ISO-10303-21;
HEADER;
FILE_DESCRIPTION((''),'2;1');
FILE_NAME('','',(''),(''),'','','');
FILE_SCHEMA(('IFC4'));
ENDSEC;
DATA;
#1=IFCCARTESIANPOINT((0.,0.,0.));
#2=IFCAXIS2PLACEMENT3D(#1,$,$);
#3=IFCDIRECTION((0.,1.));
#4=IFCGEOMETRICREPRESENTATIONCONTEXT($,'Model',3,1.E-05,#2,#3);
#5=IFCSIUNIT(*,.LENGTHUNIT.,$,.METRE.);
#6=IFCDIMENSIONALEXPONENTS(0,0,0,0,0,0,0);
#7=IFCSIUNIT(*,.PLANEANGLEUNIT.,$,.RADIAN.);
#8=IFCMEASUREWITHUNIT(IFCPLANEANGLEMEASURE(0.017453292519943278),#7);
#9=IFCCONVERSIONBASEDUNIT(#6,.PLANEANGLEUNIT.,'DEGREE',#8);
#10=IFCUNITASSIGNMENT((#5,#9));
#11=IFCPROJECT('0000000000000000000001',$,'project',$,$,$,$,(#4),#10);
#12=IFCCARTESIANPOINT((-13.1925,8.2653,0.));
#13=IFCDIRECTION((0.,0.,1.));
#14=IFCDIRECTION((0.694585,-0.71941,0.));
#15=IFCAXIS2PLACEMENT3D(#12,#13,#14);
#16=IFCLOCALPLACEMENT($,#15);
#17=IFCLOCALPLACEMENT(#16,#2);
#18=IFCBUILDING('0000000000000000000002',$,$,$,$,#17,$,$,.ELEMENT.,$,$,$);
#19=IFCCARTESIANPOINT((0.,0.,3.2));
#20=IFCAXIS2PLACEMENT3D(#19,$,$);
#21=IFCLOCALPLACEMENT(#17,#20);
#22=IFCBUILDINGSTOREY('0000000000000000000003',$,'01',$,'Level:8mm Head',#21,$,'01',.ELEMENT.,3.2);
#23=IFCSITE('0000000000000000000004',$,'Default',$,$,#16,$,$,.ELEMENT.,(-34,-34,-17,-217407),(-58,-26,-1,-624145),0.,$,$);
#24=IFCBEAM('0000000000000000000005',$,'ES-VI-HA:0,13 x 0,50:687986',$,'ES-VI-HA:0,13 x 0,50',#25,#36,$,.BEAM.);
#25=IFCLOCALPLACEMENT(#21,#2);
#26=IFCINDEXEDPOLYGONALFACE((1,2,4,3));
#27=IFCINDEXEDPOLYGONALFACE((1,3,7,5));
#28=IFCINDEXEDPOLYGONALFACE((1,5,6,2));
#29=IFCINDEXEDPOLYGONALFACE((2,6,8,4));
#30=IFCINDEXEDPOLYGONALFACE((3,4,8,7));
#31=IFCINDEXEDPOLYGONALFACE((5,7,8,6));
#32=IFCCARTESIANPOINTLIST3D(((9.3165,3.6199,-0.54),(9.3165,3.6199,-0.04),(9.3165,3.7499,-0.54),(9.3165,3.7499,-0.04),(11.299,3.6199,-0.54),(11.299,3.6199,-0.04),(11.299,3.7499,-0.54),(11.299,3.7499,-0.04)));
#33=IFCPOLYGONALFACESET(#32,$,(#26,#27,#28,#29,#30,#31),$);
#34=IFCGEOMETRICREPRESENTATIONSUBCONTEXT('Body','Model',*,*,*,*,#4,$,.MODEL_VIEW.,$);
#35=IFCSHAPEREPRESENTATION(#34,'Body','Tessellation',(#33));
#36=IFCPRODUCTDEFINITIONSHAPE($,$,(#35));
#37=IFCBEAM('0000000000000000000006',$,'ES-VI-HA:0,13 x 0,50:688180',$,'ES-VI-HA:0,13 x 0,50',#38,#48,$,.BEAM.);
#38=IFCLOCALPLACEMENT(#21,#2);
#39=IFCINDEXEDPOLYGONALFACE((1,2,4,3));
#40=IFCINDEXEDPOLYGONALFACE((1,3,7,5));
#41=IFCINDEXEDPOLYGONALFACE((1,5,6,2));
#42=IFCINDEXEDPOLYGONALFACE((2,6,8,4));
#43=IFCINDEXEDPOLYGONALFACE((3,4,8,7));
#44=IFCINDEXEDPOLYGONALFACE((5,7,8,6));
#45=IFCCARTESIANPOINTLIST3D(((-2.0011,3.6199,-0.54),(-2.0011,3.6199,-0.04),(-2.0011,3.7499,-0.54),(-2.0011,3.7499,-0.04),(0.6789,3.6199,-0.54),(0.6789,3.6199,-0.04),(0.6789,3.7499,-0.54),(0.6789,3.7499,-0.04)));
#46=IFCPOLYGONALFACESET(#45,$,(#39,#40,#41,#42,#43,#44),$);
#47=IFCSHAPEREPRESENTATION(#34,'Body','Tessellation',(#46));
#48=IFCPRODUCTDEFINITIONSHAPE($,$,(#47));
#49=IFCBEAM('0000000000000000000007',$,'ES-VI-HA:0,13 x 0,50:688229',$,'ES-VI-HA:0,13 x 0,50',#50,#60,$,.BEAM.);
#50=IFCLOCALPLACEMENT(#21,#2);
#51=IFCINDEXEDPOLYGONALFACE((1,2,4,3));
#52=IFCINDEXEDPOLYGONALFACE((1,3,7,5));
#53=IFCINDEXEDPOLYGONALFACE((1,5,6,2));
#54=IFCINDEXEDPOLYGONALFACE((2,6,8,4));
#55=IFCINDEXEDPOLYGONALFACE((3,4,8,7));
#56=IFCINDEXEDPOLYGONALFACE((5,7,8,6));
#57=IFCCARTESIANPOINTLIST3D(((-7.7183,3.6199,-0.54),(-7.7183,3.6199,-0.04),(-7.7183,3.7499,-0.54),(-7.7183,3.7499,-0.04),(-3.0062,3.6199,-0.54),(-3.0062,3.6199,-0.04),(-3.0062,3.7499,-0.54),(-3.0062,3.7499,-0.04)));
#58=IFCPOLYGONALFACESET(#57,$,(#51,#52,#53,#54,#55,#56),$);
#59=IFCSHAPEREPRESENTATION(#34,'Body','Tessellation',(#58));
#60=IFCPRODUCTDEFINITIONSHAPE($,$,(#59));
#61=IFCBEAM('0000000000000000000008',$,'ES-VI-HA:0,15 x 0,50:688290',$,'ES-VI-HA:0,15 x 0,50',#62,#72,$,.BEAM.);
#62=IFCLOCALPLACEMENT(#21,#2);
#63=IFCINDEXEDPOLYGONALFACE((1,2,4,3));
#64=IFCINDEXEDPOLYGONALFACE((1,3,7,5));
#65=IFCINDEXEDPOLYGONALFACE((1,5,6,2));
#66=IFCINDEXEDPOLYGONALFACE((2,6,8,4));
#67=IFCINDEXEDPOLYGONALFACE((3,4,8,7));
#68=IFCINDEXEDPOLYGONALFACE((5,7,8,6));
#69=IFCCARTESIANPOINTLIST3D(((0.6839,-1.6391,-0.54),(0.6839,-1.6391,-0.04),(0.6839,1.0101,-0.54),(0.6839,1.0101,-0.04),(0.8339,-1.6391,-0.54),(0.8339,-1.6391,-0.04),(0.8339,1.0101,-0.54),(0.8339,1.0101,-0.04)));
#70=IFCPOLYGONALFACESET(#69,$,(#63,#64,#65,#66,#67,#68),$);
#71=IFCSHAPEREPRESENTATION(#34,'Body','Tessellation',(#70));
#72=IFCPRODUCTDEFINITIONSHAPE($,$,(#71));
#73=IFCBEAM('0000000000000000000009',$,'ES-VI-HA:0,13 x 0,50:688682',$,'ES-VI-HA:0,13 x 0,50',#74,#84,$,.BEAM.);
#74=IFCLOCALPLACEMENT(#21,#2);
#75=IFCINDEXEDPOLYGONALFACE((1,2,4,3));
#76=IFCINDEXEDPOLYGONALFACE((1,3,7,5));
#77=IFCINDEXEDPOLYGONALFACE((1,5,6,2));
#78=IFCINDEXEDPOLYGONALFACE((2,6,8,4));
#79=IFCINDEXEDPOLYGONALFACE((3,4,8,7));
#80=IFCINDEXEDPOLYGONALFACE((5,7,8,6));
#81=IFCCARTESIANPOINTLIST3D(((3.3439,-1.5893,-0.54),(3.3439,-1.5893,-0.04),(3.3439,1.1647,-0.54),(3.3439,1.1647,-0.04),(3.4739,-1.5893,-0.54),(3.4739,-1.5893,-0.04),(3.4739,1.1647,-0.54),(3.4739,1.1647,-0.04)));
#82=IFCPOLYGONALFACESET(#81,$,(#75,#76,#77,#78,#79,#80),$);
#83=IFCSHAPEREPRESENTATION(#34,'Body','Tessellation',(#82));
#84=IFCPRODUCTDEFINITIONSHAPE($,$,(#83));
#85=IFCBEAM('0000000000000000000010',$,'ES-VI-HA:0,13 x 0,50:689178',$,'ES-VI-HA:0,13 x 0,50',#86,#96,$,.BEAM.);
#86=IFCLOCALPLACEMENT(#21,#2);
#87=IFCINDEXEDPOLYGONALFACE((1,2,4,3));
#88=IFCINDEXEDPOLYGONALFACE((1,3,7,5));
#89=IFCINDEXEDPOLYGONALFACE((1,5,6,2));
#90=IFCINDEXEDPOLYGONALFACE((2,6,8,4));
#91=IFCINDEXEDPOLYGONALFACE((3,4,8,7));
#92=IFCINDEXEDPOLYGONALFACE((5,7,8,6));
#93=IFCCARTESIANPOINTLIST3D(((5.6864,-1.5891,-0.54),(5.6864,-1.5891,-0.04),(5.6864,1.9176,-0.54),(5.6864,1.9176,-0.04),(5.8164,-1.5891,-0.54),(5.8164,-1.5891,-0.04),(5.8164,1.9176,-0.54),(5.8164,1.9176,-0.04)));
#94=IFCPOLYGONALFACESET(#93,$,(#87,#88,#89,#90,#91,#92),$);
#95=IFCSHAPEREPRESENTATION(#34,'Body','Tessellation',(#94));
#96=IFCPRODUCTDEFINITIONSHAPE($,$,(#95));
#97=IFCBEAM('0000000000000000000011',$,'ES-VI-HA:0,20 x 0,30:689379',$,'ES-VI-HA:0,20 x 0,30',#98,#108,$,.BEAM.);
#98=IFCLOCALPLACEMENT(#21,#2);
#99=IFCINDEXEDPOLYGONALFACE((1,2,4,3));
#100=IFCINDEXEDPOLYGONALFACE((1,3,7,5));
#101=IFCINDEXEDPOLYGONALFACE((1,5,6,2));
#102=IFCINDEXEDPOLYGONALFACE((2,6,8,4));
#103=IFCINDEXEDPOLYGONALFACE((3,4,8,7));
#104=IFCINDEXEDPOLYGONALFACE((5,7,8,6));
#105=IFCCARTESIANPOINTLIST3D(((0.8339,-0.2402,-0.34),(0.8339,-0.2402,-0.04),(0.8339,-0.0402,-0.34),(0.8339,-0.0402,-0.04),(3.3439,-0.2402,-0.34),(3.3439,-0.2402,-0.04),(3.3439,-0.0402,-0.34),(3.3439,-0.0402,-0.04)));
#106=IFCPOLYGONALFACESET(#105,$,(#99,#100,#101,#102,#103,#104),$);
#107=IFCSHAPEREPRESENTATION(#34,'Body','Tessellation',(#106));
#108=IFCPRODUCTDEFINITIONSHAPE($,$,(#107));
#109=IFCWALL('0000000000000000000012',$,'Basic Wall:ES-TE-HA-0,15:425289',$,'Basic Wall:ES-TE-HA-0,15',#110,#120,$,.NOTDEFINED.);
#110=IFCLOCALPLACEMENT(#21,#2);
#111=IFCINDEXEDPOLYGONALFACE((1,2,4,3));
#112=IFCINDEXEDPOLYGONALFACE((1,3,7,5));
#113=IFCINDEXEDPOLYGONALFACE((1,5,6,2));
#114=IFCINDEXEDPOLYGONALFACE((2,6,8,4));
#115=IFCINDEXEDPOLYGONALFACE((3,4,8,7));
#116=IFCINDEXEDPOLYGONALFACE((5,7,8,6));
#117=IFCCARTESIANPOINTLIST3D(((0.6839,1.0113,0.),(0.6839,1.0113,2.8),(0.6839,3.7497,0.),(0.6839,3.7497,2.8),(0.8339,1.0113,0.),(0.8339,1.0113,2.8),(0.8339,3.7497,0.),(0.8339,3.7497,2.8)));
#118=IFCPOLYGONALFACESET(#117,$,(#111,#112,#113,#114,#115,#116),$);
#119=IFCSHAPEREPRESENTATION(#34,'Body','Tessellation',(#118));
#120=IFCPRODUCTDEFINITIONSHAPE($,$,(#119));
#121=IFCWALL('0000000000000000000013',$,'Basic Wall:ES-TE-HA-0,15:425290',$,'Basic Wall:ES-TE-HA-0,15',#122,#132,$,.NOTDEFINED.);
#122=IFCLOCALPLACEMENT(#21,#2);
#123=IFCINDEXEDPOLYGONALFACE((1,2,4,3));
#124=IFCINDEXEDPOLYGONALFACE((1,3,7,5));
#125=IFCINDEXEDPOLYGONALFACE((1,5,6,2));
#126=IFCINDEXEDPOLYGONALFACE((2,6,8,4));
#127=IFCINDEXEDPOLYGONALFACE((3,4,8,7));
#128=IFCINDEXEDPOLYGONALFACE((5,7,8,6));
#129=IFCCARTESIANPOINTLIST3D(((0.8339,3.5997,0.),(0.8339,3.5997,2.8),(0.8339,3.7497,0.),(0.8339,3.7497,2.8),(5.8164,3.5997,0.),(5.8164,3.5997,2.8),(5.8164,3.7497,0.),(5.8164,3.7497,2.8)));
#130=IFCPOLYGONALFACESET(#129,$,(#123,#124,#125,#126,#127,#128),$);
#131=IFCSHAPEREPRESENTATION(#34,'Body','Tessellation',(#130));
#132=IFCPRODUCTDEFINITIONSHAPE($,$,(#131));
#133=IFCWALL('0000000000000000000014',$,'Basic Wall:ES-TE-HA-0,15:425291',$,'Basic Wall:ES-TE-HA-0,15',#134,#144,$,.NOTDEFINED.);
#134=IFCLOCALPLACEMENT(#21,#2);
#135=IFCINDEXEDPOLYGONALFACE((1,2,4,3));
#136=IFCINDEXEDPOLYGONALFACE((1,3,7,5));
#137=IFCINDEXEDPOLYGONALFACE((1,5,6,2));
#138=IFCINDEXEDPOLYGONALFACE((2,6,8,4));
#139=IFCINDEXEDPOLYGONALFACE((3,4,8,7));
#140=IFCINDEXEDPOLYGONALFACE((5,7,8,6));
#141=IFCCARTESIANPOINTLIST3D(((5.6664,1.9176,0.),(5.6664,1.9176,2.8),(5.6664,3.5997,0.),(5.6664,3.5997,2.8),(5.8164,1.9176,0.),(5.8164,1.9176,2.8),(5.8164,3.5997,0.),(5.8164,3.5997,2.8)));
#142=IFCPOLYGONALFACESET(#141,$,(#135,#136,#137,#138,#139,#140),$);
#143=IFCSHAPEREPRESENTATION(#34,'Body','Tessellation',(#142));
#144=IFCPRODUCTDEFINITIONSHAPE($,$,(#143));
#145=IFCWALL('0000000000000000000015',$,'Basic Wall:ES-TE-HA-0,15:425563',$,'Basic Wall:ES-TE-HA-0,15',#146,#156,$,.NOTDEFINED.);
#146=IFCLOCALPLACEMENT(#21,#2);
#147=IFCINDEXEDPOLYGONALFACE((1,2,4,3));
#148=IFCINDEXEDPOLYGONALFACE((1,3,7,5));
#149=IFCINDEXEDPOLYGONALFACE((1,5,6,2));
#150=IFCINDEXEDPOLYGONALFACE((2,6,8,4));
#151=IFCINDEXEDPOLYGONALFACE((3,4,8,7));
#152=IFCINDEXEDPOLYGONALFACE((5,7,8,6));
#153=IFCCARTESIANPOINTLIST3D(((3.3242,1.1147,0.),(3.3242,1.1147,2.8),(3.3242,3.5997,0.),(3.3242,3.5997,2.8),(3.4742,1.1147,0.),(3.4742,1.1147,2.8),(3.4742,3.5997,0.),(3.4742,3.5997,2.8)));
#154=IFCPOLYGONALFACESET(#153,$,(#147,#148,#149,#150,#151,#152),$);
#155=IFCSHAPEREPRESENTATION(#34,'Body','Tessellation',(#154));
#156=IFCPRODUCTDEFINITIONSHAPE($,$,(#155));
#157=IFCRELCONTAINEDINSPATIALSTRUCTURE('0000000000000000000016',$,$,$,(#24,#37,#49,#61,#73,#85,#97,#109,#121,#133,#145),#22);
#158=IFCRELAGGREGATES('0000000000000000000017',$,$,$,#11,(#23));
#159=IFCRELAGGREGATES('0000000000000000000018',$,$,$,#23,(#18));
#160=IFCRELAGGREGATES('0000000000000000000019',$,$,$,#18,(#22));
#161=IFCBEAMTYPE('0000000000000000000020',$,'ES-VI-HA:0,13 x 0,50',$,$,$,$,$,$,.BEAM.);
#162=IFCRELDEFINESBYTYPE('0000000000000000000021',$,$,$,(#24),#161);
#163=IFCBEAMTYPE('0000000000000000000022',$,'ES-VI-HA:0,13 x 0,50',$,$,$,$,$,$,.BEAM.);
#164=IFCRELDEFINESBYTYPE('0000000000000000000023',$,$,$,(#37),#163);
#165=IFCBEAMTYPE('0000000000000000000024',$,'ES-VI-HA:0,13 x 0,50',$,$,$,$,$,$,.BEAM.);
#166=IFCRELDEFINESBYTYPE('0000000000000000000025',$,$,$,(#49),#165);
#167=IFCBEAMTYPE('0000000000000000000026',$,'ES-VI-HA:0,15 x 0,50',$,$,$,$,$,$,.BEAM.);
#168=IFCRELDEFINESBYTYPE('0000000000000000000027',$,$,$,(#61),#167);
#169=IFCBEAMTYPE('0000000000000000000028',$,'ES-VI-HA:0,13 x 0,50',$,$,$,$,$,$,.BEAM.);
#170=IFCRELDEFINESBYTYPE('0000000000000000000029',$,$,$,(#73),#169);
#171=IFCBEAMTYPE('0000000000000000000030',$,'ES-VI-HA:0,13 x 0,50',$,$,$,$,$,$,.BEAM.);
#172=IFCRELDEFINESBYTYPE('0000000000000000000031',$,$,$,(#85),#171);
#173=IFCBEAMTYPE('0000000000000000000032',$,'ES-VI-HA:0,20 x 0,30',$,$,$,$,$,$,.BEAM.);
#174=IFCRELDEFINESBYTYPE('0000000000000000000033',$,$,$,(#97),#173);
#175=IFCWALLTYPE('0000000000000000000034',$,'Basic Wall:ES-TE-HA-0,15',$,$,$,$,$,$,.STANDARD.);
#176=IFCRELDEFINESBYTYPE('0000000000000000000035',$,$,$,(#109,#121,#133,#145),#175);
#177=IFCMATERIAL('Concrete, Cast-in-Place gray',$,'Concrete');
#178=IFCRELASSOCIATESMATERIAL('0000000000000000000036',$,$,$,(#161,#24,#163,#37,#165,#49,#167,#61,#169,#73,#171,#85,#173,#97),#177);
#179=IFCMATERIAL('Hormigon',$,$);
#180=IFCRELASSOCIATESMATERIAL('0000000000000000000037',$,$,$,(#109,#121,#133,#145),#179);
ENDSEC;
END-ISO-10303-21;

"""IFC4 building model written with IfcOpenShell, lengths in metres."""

from ifc_helpers import new_model, entity, si_unit, converted_unit, direction, frame, origin, place, context, subcontext, project, spatial, indexed_curve, outline, extrude, source, transform, mapped, material, type_object, type_shapes, element, save


model = new_model("IFC4")

# Units and contexts
model_context = context("Model", 3, precision=1e-05, world=origin(), true_north=direction((0.0, 1.0)))
body_context = subcontext(model_context, "Body", "Model", "MODEL_VIEW")
ifc_project = project(units=[si_unit("LENGTHUNIT", "METRE"), converted_unit("PLANEANGLEUNIT", "DEGREE", entity("IfcPlaneAngleMeasure", 0.017453292519943278), si_unit("PLANEANGLEUNIT", "RADIAN"), dimensions=[0, 0, 0, 0, 0, 0, 0])], contexts=[model_context])

# Site, building, storey
site_placement = place(None, frame((-13.1925, 8.2653, 0.0), z_axis=(0.0, 0.0, 1.0), x_axis=(0.694585, -0.71941, 0.0)))
site = spatial("IfcSite", under=ifc_project, at=site_placement, Name="Default", CompositionType="ELEMENT", RefLatitude=(-34, -34, -17, -217407), RefLongitude=(-58, -26, -1, -624145), RefElevation=0.0)
building_placement = place(site_placement, origin())
building = spatial("IfcBuilding", under=site, at=building_placement, CompositionType="ELEMENT")
storey_placement = place(building_placement, frame((0.0, 0.0, 3.2)))
storey = spatial("IfcBuildingStorey", under=building, at=storey_placement, Name="01", ObjectType="Level:8mm Head", LongName="01", CompositionType="ELEMENT", Elevation=3.2)

# Beams
ifc_material_1 = material(Name="Concrete, Cast-in-Place gray", Category="Concrete")
beam_type_1 = type_object("IfcBeamType", Name="ES-VI-HA:0,13 x 0,50", PredefinedType="BEAM", material=ifc_material_1)
shared_shape_1 = source(origin(), body_context, "Body", "SweptSolid", [
    extrude(outline(indexed_curve([(-0.25, -0.065), (0.25, -0.065), (0.25, 0.065), (-0.25, 0.065), (-0.25, -0.065)], self_intersect=False)), frame((9.3165, 3.6849, 2.91), z_axis=(1.0, 0.0, 0.0), x_axis=(0.0, 0.0, -1.0)), (0.0, 0.0, 1.0), 1.9825),
])
type_shapes(beam_type_1, [shared_shape_1])
beam_1_placement = place(storey_placement, frame((0.0, 0.0, -3.2)))
element("IfcBeam", 1, at=beam_1_placement, inside=storey, type_object=beam_type_1, material=ifc_material_1, Name="ES-VI-HA:0,13 x 0,50:687986", ObjectType="ES-VI-HA:0,13 x 0,50", PredefinedType="BEAM", context=body_context, shape_type="MappedRepresentation", body=[
    mapped(shared_shape_1, transform((0.0, 0.0, 0.0), scale=1.0)),
])
beam_type_2 = type_object("IfcBeamType", Name="ES-VI-HA:0,13 x 0,50", PredefinedType="BEAM", material=ifc_material_1)
shared_shape_2 = source(origin(), body_context, "Body", "SweptSolid", [
    extrude(outline(indexed_curve([(-0.25, -0.065), (0.25, -0.065), (0.25, 0.065), (-0.25, 0.065), (-0.25, -0.065)], self_intersect=False)), frame((-2.0011, 3.6849, 2.91), z_axis=(1.0, 0.0, 0.0), x_axis=(0.0, 0.0, -1.0)), (0.0, 0.0, 1.0), 2.68),
])
type_shapes(beam_type_2, [shared_shape_2])
beam_2_placement = place(storey_placement, frame((0.0, 0.0, -3.2)))
element("IfcBeam", 2, at=beam_2_placement, inside=storey, type_object=beam_type_2, material=ifc_material_1, Name="ES-VI-HA:0,13 x 0,50:688180", ObjectType="ES-VI-HA:0,13 x 0,50", PredefinedType="BEAM", context=body_context, shape_type="MappedRepresentation", body=[
    mapped(shared_shape_2, transform((0.0, 0.0, 0.0), scale=1.0)),
])
beam_type_3 = type_object("IfcBeamType", Name="ES-VI-HA:0,13 x 0,50", PredefinedType="BEAM", material=ifc_material_1)
shared_shape_3 = source(origin(), body_context, "Body", "SweptSolid", [
    extrude(outline(indexed_curve([(-0.25, -0.065), (0.25, -0.065), (0.25, 0.065), (-0.25, 0.065), (-0.25, -0.065)], self_intersect=False)), frame((-7.7183, 3.6849, 2.91), z_axis=(1.0, 0.0, 0.0), x_axis=(0.0, 0.0, -1.0)), (0.0, 0.0, 1.0), 4.712),
])
type_shapes(beam_type_3, [shared_shape_3])
beam_3_placement = place(storey_placement, frame((0.0, 0.0, -3.2)))
element("IfcBeam", 3, at=beam_3_placement, inside=storey, type_object=beam_type_3, material=ifc_material_1, Name="ES-VI-HA:0,13 x 0,50:688229", ObjectType="ES-VI-HA:0,13 x 0,50", PredefinedType="BEAM", context=body_context, shape_type="MappedRepresentation", body=[
    mapped(shared_shape_3, transform((0.0, 0.0, 0.0), scale=1.0)),
])
beam_type_4 = type_object("IfcBeamType", Name="ES-VI-HA:0,15 x 0,50", PredefinedType="BEAM", material=ifc_material_1)
shared_shape_4 = source(origin(), body_context, "Body", "SweptSolid", [
    extrude(outline(indexed_curve([(-0.075, -0.25), (0.075, -0.25), (0.075, 0.25), (-0.075, 0.25), (-0.075, -0.25)], self_intersect=False)), frame((0.7589, -1.6391, 2.91), z_axis=(0.0, 1.0, 0.0), x_axis=(-1.0, 0.0, 0.0)), (0.0, 0.0, 1.0), 2.6491),
])
type_shapes(beam_type_4, [shared_shape_4])
beam_4_placement = place(storey_placement, frame((0.0, 0.0, -3.2)))
element("IfcBeam", 4, at=beam_4_placement, inside=storey, type_object=beam_type_4, material=ifc_material_1, Name="ES-VI-HA:0,15 x 0,50:688290", ObjectType="ES-VI-HA:0,15 x 0,50", PredefinedType="BEAM", context=body_context, shape_type="MappedRepresentation", body=[
    mapped(shared_shape_4, transform((0.0, 0.0, 0.0), scale=1.0)),
])
beam_type_5 = type_object("IfcBeamType", Name="ES-VI-HA:0,13 x 0,50", PredefinedType="BEAM", material=ifc_material_1)
shared_shape_5 = source(origin(), body_context, "Body", "SweptSolid", [
    extrude(outline(indexed_curve([(-0.065, -0.25), (0.065, -0.25), (0.065, 0.25), (-0.065, 0.25), (-0.065, -0.25)], self_intersect=False)), frame((3.4089, -1.5893, 2.91), z_axis=(0.0, 1.0, 0.0), x_axis=(-1.0, 0.0, 0.0)), (0.0, 0.0, 1.0), 2.7539),
])
type_shapes(beam_type_5, [shared_shape_5])
beam_5_placement = place(storey_placement, frame((0.0, 0.0, -3.2)))
element("IfcBeam", 5, at=beam_5_placement, inside=storey, type_object=beam_type_5, material=ifc_material_1, Name="ES-VI-HA:0,13 x 0,50:688682", ObjectType="ES-VI-HA:0,13 x 0,50", PredefinedType="BEAM", context=body_context, shape_type="MappedRepresentation", body=[
    mapped(shared_shape_5, transform((0.0, 0.0, 0.0), scale=1.0)),
])
beam_type_6 = type_object("IfcBeamType", Name="ES-VI-HA:0,13 x 0,50", PredefinedType="BEAM", material=ifc_material_1)
shared_shape_6 = source(origin(), body_context, "Body", "SweptSolid", [
    extrude(outline(indexed_curve([(-0.065, -0.25), (0.065, -0.25), (0.065, 0.25), (-0.065, 0.25), (-0.065, -0.25)], self_intersect=False)), frame((5.7514, -1.5891, 2.91), z_axis=(0.0, 1.0, 0.0), x_axis=(-1.0, 0.0, 0.0)), (0.0, 0.0, 1.0), 3.5067),
])
type_shapes(beam_type_6, [shared_shape_6])
beam_6_placement = place(storey_placement, frame((0.0, 0.0, -3.2)))
element("IfcBeam", 6, at=beam_6_placement, inside=storey, type_object=beam_type_6, material=ifc_material_1, Name="ES-VI-HA:0,13 x 0,50:689178", ObjectType="ES-VI-HA:0,13 x 0,50", PredefinedType="BEAM", context=body_context, shape_type="MappedRepresentation", body=[
    mapped(shared_shape_6, transform((0.0, 0.0, 0.0), scale=1.0)),
])
beam_type_7 = type_object("IfcBeamType", Name="ES-VI-HA:0,20 x 0,30", PredefinedType="BEAM", material=ifc_material_1)
shared_shape_7 = source(origin(), body_context, "Body", "SweptSolid", [
    extrude(outline(indexed_curve([(-0.15, -0.1), (0.15, -0.1), (0.15, 0.1), (-0.15, 0.1), (-0.15, -0.1)], self_intersect=False)), frame((0.8339, -0.1402, 3.01), z_axis=(1.0, 0.0, 0.0), x_axis=(0.0, 0.0, -1.0)), (0.0, 0.0, 1.0), 2.51),
])
type_shapes(beam_type_7, [shared_shape_7])
beam_7_placement = place(storey_placement, frame((0.0, 0.0, -3.2)))
element("IfcBeam", 7, at=beam_7_placement, inside=storey, type_object=beam_type_7, material=ifc_material_1, Name="ES-VI-HA:0,20 x 0,30:689379", ObjectType="ES-VI-HA:0,20 x 0,30", PredefinedType="BEAM", context=body_context, shape_type="MappedRepresentation", body=[
    mapped(shared_shape_7, transform((0.0, 0.0, 0.0), scale=1.0)),
])

# Shared definitions
ifc_material_2 = material(Name="Hormigon")

# Walls
wall_type = type_object("IfcWallType", Name="Basic Wall:ES-TE-HA-0,15", PredefinedType="STANDARD")
wall_1_placement = place(storey_placement, frame((0.7589, 1.0113, 0.0), z_axis=(0.0, 0.0, 1.0), x_axis=(0.0, 1.0, 0.0)))
element("IfcWall", 8, at=wall_1_placement, inside=storey, type_object=wall_type, material=ifc_material_2, Name="Basic Wall:ES-TE-HA-0,15:425289", ObjectType="Basic Wall:ES-TE-HA-0,15", PredefinedType="NOTDEFINED", context=body_context, shape_type="SweptSolid", body=[
    extrude(outline(indexed_curve([(2.7384, 0.075), (0.0, 0.075), (0.0, -0.075), (2.7384, -0.075), (2.7384, 0.075)], self_intersect=False)), origin(), (0.0, 0.0, 1.0), 2.8),
])
wall_2_placement = place(storey_placement, frame((0.8339, 3.6747, 0.0)))
element("IfcWall", 9, at=wall_2_placement, inside=storey, type_object=wall_type, material=ifc_material_2, Name="Basic Wall:ES-TE-HA-0,15:425290", ObjectType="Basic Wall:ES-TE-HA-0,15", PredefinedType="NOTDEFINED", context=body_context, shape_type="SweptSolid", body=[
    extrude(outline(indexed_curve([(4.9825, 0.075), (0.0, 0.075), (0.0, -0.075), (4.9825, -0.075), (4.9825, 0.075)], self_intersect=False)), origin(), (0.0, 0.0, 1.0), 2.8),
])
wall_3_placement = place(storey_placement, frame((5.7414, 1.9176, 0.0), z_axis=(0.0, 0.0, 1.0), x_axis=(0.0, 1.0, 0.0)))
element("IfcWall", 10, at=wall_3_placement, inside=storey, type_object=wall_type, material=ifc_material_2, Name="Basic Wall:ES-TE-HA-0,15:425291", ObjectType="Basic Wall:ES-TE-HA-0,15", PredefinedType="NOTDEFINED", context=body_context, shape_type="SweptSolid", body=[
    extrude(outline(indexed_curve([(1.682, 0.075), (0.0, 0.075), (0.0, -0.075), (1.682, -0.075), (1.682, 0.075)], self_intersect=False)), origin(), (0.0, 0.0, 1.0), 2.8),
])
wall_4_placement = place(storey_placement, frame((3.3992, 3.5997, 0.0), z_axis=(0.0, 0.0, 1.0), x_axis=(0.0, -1.0, 0.0)))
element("IfcWall", 11, at=wall_4_placement, inside=storey, type_object=wall_type, material=ifc_material_2, Name="Basic Wall:ES-TE-HA-0,15:425563", ObjectType="Basic Wall:ES-TE-HA-0,15", PredefinedType="NOTDEFINED", context=body_context, shape_type="SweptSolid", body=[
    extrude(outline(indexed_curve([(2.485, 0.075), (0.0, 0.075), (0.0, -0.075), (2.485, -0.075), (2.485, 0.075)], self_intersect=False)), origin(), (0.0, 0.0, 1.0), 2.8),
])

save(model, "model.ifc")
